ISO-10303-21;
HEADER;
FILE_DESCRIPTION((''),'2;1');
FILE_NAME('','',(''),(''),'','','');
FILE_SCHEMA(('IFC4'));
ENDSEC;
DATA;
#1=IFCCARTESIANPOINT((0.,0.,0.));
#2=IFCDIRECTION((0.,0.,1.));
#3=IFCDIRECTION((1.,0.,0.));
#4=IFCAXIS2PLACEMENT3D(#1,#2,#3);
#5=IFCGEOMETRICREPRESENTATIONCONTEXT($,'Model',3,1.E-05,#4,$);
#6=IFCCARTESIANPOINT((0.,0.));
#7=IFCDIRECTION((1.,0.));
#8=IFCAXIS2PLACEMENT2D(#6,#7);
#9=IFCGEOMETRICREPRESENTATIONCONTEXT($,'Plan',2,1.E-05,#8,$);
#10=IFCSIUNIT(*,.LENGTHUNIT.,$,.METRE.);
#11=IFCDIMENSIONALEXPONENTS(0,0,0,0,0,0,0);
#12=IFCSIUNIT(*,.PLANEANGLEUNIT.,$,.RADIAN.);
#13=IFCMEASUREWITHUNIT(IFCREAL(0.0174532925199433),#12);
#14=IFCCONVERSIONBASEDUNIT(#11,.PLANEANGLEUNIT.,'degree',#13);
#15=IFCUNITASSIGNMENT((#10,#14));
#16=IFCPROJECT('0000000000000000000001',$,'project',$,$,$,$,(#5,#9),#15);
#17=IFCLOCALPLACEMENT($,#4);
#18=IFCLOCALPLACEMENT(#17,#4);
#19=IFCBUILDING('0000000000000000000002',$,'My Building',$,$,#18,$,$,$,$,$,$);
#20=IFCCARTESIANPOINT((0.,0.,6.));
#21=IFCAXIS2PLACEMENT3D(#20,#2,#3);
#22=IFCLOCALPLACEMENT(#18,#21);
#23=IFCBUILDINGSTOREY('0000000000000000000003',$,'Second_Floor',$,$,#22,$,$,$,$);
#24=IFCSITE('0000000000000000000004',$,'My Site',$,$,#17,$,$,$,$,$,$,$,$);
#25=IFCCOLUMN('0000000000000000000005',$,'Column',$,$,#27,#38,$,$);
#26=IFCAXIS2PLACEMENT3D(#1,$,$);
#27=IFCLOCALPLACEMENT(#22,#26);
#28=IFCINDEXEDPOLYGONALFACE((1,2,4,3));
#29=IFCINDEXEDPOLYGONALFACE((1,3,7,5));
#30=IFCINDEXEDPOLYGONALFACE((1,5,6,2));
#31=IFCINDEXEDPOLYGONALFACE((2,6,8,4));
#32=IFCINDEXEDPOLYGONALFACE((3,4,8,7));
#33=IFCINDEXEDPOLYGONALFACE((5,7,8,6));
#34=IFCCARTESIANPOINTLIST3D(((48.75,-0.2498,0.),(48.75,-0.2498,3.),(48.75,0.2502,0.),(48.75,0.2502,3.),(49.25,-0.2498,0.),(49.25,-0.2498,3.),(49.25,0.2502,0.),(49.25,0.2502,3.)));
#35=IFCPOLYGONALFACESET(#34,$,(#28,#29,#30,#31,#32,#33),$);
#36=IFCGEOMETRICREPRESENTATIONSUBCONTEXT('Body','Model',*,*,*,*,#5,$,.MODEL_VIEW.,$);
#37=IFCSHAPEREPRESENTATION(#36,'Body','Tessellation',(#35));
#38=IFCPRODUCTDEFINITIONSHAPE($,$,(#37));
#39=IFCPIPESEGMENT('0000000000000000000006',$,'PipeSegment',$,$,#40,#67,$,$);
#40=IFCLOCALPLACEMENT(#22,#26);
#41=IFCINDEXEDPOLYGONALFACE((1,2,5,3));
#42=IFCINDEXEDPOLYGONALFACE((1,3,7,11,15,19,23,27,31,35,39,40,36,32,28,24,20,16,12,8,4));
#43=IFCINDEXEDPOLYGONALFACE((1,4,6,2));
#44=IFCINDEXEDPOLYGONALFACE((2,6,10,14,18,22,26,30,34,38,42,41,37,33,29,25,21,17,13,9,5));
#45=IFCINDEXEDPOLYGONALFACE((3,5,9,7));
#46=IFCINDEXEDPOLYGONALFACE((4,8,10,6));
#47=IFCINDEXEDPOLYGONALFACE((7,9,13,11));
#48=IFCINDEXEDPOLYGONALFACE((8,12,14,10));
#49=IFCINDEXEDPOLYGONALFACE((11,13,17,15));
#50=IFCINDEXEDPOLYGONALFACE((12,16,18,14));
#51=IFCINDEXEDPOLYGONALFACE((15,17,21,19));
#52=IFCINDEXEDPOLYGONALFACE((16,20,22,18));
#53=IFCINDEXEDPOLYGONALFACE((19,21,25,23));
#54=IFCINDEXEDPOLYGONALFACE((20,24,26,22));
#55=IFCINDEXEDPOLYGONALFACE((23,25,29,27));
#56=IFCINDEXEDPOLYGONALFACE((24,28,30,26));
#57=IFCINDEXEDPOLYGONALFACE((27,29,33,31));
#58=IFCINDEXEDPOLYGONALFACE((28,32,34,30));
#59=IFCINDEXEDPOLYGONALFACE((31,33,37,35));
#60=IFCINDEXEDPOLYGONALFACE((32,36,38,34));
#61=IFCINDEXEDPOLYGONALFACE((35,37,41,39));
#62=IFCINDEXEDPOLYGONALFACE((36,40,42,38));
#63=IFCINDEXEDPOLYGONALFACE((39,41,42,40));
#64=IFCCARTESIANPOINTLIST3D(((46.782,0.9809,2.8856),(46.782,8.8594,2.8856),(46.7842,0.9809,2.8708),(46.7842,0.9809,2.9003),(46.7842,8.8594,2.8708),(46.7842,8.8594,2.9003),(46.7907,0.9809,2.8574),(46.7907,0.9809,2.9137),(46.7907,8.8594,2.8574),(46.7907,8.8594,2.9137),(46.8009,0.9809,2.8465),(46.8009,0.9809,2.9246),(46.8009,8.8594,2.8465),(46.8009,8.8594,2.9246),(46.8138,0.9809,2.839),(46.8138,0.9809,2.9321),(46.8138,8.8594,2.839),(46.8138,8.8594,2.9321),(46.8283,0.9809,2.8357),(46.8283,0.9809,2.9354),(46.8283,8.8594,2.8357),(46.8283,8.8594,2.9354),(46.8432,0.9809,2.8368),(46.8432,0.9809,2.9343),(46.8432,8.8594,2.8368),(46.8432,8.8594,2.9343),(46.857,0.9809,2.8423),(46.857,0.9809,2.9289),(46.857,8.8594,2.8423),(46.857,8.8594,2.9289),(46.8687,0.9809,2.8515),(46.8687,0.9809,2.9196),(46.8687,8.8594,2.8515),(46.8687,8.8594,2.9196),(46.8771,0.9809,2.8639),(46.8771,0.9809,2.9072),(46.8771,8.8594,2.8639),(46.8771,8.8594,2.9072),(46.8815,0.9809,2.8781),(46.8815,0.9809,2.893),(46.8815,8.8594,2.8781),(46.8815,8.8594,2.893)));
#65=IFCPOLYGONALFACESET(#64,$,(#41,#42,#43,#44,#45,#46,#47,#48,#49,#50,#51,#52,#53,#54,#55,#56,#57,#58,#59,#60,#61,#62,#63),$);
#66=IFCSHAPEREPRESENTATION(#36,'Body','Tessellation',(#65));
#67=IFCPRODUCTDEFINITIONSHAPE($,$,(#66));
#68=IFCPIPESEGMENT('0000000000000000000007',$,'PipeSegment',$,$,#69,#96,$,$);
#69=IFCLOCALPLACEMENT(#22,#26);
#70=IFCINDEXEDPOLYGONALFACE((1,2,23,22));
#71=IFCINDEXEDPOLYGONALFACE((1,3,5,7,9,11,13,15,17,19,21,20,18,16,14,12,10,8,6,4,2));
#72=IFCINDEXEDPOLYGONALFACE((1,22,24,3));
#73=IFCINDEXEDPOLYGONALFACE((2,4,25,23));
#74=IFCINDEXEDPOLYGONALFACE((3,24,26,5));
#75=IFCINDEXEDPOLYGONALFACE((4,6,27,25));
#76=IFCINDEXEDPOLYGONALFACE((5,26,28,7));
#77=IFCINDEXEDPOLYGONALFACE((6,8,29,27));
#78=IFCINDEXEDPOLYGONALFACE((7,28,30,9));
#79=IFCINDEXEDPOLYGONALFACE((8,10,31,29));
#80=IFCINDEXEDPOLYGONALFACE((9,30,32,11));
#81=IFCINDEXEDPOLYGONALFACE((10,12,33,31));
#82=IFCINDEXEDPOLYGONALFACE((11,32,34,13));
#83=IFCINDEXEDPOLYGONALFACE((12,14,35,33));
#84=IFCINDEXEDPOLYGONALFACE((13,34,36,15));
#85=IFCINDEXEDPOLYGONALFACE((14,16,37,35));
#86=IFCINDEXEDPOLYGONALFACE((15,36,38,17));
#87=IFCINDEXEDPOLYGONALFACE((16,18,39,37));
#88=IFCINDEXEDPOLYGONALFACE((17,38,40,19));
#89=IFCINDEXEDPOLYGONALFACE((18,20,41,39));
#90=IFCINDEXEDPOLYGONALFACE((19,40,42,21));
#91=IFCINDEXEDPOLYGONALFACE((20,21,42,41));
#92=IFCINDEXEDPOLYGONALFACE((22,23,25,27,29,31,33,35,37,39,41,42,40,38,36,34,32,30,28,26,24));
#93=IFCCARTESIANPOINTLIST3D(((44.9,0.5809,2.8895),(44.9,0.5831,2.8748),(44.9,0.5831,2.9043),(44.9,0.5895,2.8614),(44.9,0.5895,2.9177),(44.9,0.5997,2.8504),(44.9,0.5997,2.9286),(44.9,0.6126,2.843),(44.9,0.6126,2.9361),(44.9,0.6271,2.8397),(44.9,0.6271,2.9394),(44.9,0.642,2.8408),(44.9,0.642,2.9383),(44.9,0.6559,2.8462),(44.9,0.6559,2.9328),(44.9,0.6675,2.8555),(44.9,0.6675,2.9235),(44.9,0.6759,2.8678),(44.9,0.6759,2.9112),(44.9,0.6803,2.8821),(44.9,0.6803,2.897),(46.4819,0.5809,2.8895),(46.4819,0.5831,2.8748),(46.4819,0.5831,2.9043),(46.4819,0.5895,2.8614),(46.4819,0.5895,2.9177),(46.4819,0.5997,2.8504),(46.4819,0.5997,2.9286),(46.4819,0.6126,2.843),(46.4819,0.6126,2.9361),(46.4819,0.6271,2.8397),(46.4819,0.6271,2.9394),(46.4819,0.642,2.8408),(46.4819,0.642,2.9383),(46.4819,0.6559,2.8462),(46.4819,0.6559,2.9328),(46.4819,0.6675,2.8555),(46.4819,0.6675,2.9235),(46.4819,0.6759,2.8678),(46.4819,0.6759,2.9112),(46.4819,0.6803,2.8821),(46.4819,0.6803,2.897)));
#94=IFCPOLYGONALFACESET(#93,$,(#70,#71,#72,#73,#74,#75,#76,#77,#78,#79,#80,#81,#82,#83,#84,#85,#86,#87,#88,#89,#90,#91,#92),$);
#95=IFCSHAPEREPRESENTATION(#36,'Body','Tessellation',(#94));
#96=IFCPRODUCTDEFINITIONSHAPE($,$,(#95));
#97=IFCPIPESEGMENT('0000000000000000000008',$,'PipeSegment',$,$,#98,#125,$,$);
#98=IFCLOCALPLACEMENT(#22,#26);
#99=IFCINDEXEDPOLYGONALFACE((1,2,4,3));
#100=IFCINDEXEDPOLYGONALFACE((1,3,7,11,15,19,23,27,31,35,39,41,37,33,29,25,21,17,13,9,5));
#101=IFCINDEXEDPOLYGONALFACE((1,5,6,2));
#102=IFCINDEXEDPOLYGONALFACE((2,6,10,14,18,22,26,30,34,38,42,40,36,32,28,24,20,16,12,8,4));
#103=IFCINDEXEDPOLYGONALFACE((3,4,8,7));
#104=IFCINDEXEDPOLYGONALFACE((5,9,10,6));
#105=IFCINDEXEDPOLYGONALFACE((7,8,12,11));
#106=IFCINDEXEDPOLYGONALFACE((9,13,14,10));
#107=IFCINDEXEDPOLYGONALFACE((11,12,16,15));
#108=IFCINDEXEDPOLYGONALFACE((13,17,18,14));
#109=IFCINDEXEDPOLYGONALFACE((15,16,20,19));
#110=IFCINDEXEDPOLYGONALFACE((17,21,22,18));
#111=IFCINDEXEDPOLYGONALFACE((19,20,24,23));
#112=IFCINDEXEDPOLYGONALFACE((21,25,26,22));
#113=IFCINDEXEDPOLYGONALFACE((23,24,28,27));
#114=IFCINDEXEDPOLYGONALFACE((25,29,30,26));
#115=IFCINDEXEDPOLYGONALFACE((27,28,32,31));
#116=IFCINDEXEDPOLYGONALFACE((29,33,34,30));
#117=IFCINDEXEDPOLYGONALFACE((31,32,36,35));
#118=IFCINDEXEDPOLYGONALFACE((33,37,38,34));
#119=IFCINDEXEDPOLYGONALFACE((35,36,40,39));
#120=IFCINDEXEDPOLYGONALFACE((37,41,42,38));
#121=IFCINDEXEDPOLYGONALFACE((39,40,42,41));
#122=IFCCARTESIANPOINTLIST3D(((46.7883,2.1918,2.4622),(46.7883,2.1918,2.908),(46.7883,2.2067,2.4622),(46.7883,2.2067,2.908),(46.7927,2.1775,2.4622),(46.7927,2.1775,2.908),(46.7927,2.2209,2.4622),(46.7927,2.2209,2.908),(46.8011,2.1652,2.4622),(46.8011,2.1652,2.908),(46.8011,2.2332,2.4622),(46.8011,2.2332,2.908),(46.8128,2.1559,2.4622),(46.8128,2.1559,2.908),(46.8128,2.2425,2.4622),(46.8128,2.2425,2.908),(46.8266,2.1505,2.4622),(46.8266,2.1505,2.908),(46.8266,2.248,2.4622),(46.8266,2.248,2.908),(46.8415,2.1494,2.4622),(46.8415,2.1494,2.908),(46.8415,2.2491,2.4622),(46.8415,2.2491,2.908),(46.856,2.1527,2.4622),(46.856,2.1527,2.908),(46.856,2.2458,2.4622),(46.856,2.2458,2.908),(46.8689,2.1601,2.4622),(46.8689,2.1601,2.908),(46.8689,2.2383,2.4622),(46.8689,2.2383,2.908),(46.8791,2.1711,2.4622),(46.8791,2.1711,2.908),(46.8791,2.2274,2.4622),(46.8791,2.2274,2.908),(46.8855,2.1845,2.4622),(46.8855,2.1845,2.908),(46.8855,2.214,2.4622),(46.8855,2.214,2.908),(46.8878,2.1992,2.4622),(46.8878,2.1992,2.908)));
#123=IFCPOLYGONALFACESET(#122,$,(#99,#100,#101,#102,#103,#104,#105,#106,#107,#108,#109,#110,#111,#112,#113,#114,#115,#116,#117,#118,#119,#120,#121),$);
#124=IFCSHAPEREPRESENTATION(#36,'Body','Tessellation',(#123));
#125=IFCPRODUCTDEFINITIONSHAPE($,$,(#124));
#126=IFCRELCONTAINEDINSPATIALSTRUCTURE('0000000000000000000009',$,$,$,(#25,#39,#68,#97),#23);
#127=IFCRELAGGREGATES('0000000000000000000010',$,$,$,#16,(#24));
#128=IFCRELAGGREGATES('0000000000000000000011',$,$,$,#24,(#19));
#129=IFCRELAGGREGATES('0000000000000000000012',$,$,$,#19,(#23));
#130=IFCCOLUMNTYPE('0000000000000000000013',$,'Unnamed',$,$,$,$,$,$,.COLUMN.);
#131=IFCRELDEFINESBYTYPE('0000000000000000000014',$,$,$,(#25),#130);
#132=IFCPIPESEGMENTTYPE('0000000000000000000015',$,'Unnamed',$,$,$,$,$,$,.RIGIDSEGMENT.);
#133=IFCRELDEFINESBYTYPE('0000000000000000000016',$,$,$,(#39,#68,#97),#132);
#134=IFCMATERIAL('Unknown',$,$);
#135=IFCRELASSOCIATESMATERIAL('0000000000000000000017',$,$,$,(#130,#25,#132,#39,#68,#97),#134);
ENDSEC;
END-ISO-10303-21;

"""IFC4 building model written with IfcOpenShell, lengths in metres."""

from ifc_helpers import new_model, entity, si_unit, converted_unit, frame, origin_with_axes, origin_2d_with_axis, place, context, subcontext, project, spatial, rectangle, circle, extrude, material, material_profile, profile_set, profile_usage, type_object, element, save


model = new_model("IFC4")

# Units and contexts
model_context = context("Model", 3, precision=1e-05, world=origin_with_axes())
plan_context = context("Plan", 2, precision=1e-05, world=origin_2d_with_axis())
body_context = subcontext(model_context, "Body", "Model", "MODEL_VIEW")
ifc_project = project(units=[si_unit("LENGTHUNIT", "METRE"), converted_unit("PLANEANGLEUNIT", "degree", entity("IfcReal", 0.0174532925199433), si_unit("PLANEANGLEUNIT", "RADIAN"), dimensions=[0, 0, 0, 0, 0, 0, 0])], contexts=[model_context, plan_context])

# Site, building, storey
site_placement = place(None, origin_with_axes())
site = spatial("IfcSite", under=ifc_project, at=site_placement, Name="My Site")
building_placement = place(site_placement, origin_with_axes())
building = spatial("IfcBuilding", under=site, at=building_placement, Name="My Building")
storey_placement = place(building_placement, frame((0.0, 0.0, 6.0), z_axis=(0.0, 0.0, 1.0), x_axis=(1.0, 0.0, 0.0)))
storey = spatial("IfcBuildingStorey", under=building, at=storey_placement, Name="Second_Floor")

# Column
ifc_material = material(Name="Unknown")
ifc_material_profile_1 = material_profile(ifc_material, rectangle(XDim=0.5, YDim=0.5))
ifc_profile_set_1 = profile_set([ifc_material_profile_1])
ifc_profile_usage_1 = profile_usage(ifc_profile_set_1, cardinal=5)
column_type = type_object("IfcColumnType", Name="Unnamed", PredefinedType="COLUMN", material=ifc_profile_set_1)
column_placement = place(storey_placement, frame((49.0, 0.0002, 0.0), z_axis=(0.0, 0.0, 1.0), x_axis=(1.0, 0.0, 0.0)))
element("IfcColumn", 1, at=column_placement, inside=storey, type_object=column_type, material=ifc_profile_usage_1, Name="Column", context=body_context, shape_type="SweptSolid", body=[
    extrude(rectangle(XDim=0.5, YDim=0.5), origin_with_axes(), (0.0, 0.0, 1.0), 3.0),
])

# Pipe segments
ifc_material_profile_2 = material_profile(ifc_material, circle(Radius=0.05))
ifc_profile_set_2 = profile_set([ifc_material_profile_2])
ifc_profile_usage_2 = profile_usage(ifc_profile_set_2, cardinal=5)
pipe_segment_type = type_object("IfcPipeSegmentType", Name="Unnamed", PredefinedType="RIGIDSEGMENT", material=ifc_profile_set_2)
pipe_segment_1_placement = place(storey_placement, frame((46.832, 0.9809, 2.8856), z_axis=(0.0, 1.0, 0.0), x_axis=(-1.0, 0.0, 0.0)))
element("IfcPipeSegment", 2, at=pipe_segment_1_placement, inside=storey, type_object=pipe_segment_type, material=ifc_profile_usage_2, Name="PipeSegment", context=body_context, shape_type="SweptSolid", body=[
    extrude(circle(Radius=0.05), origin_with_axes(), (0.0, 0.0, 1.0), 7.8786),
])
ifc_profile_usage_3 = profile_usage(ifc_profile_set_2, cardinal=6)
pipe_segment_2_placement = place(storey_placement, frame((46.4819, 0.6809, 2.8895), z_axis=(-1.0, 0.0, 0.0), x_axis=(0.0, -1.0, 0.0)))
element("IfcPipeSegment", 3, at=pipe_segment_2_placement, inside=storey, type_object=pipe_segment_type, material=ifc_profile_usage_3, Name="PipeSegment", context=body_context, shape_type="SweptSolid", body=[
    extrude(circle(Radius=0.05), frame((0.05, 0.0, 0.0), z_axis=(0.0, 0.0, 1.0), x_axis=(1.0, 0.0, 0.0)), (0.0, 0.0, 1.0), 1.5819),
])
ifc_profile_usage_4 = profile_usage(ifc_profile_set_2, cardinal=5)
pipe_segment_3_placement = place(storey_placement, frame((46.8378, 2.1992, 2.908), z_axis=(0.0, 0.0, -1.0), x_axis=(1.0, 0.0, 0.0)))
element("IfcPipeSegment", 4, at=pipe_segment_3_placement, inside=storey, type_object=pipe_segment_type, material=ifc_profile_usage_4, Name="PipeSegment", context=body_context, shape_type="SweptSolid", body=[
    extrude(circle(Radius=0.05), origin_with_axes(), (0.0, 0.0, 1.0), 0.4458),
])

save(model, "model.ifc")
